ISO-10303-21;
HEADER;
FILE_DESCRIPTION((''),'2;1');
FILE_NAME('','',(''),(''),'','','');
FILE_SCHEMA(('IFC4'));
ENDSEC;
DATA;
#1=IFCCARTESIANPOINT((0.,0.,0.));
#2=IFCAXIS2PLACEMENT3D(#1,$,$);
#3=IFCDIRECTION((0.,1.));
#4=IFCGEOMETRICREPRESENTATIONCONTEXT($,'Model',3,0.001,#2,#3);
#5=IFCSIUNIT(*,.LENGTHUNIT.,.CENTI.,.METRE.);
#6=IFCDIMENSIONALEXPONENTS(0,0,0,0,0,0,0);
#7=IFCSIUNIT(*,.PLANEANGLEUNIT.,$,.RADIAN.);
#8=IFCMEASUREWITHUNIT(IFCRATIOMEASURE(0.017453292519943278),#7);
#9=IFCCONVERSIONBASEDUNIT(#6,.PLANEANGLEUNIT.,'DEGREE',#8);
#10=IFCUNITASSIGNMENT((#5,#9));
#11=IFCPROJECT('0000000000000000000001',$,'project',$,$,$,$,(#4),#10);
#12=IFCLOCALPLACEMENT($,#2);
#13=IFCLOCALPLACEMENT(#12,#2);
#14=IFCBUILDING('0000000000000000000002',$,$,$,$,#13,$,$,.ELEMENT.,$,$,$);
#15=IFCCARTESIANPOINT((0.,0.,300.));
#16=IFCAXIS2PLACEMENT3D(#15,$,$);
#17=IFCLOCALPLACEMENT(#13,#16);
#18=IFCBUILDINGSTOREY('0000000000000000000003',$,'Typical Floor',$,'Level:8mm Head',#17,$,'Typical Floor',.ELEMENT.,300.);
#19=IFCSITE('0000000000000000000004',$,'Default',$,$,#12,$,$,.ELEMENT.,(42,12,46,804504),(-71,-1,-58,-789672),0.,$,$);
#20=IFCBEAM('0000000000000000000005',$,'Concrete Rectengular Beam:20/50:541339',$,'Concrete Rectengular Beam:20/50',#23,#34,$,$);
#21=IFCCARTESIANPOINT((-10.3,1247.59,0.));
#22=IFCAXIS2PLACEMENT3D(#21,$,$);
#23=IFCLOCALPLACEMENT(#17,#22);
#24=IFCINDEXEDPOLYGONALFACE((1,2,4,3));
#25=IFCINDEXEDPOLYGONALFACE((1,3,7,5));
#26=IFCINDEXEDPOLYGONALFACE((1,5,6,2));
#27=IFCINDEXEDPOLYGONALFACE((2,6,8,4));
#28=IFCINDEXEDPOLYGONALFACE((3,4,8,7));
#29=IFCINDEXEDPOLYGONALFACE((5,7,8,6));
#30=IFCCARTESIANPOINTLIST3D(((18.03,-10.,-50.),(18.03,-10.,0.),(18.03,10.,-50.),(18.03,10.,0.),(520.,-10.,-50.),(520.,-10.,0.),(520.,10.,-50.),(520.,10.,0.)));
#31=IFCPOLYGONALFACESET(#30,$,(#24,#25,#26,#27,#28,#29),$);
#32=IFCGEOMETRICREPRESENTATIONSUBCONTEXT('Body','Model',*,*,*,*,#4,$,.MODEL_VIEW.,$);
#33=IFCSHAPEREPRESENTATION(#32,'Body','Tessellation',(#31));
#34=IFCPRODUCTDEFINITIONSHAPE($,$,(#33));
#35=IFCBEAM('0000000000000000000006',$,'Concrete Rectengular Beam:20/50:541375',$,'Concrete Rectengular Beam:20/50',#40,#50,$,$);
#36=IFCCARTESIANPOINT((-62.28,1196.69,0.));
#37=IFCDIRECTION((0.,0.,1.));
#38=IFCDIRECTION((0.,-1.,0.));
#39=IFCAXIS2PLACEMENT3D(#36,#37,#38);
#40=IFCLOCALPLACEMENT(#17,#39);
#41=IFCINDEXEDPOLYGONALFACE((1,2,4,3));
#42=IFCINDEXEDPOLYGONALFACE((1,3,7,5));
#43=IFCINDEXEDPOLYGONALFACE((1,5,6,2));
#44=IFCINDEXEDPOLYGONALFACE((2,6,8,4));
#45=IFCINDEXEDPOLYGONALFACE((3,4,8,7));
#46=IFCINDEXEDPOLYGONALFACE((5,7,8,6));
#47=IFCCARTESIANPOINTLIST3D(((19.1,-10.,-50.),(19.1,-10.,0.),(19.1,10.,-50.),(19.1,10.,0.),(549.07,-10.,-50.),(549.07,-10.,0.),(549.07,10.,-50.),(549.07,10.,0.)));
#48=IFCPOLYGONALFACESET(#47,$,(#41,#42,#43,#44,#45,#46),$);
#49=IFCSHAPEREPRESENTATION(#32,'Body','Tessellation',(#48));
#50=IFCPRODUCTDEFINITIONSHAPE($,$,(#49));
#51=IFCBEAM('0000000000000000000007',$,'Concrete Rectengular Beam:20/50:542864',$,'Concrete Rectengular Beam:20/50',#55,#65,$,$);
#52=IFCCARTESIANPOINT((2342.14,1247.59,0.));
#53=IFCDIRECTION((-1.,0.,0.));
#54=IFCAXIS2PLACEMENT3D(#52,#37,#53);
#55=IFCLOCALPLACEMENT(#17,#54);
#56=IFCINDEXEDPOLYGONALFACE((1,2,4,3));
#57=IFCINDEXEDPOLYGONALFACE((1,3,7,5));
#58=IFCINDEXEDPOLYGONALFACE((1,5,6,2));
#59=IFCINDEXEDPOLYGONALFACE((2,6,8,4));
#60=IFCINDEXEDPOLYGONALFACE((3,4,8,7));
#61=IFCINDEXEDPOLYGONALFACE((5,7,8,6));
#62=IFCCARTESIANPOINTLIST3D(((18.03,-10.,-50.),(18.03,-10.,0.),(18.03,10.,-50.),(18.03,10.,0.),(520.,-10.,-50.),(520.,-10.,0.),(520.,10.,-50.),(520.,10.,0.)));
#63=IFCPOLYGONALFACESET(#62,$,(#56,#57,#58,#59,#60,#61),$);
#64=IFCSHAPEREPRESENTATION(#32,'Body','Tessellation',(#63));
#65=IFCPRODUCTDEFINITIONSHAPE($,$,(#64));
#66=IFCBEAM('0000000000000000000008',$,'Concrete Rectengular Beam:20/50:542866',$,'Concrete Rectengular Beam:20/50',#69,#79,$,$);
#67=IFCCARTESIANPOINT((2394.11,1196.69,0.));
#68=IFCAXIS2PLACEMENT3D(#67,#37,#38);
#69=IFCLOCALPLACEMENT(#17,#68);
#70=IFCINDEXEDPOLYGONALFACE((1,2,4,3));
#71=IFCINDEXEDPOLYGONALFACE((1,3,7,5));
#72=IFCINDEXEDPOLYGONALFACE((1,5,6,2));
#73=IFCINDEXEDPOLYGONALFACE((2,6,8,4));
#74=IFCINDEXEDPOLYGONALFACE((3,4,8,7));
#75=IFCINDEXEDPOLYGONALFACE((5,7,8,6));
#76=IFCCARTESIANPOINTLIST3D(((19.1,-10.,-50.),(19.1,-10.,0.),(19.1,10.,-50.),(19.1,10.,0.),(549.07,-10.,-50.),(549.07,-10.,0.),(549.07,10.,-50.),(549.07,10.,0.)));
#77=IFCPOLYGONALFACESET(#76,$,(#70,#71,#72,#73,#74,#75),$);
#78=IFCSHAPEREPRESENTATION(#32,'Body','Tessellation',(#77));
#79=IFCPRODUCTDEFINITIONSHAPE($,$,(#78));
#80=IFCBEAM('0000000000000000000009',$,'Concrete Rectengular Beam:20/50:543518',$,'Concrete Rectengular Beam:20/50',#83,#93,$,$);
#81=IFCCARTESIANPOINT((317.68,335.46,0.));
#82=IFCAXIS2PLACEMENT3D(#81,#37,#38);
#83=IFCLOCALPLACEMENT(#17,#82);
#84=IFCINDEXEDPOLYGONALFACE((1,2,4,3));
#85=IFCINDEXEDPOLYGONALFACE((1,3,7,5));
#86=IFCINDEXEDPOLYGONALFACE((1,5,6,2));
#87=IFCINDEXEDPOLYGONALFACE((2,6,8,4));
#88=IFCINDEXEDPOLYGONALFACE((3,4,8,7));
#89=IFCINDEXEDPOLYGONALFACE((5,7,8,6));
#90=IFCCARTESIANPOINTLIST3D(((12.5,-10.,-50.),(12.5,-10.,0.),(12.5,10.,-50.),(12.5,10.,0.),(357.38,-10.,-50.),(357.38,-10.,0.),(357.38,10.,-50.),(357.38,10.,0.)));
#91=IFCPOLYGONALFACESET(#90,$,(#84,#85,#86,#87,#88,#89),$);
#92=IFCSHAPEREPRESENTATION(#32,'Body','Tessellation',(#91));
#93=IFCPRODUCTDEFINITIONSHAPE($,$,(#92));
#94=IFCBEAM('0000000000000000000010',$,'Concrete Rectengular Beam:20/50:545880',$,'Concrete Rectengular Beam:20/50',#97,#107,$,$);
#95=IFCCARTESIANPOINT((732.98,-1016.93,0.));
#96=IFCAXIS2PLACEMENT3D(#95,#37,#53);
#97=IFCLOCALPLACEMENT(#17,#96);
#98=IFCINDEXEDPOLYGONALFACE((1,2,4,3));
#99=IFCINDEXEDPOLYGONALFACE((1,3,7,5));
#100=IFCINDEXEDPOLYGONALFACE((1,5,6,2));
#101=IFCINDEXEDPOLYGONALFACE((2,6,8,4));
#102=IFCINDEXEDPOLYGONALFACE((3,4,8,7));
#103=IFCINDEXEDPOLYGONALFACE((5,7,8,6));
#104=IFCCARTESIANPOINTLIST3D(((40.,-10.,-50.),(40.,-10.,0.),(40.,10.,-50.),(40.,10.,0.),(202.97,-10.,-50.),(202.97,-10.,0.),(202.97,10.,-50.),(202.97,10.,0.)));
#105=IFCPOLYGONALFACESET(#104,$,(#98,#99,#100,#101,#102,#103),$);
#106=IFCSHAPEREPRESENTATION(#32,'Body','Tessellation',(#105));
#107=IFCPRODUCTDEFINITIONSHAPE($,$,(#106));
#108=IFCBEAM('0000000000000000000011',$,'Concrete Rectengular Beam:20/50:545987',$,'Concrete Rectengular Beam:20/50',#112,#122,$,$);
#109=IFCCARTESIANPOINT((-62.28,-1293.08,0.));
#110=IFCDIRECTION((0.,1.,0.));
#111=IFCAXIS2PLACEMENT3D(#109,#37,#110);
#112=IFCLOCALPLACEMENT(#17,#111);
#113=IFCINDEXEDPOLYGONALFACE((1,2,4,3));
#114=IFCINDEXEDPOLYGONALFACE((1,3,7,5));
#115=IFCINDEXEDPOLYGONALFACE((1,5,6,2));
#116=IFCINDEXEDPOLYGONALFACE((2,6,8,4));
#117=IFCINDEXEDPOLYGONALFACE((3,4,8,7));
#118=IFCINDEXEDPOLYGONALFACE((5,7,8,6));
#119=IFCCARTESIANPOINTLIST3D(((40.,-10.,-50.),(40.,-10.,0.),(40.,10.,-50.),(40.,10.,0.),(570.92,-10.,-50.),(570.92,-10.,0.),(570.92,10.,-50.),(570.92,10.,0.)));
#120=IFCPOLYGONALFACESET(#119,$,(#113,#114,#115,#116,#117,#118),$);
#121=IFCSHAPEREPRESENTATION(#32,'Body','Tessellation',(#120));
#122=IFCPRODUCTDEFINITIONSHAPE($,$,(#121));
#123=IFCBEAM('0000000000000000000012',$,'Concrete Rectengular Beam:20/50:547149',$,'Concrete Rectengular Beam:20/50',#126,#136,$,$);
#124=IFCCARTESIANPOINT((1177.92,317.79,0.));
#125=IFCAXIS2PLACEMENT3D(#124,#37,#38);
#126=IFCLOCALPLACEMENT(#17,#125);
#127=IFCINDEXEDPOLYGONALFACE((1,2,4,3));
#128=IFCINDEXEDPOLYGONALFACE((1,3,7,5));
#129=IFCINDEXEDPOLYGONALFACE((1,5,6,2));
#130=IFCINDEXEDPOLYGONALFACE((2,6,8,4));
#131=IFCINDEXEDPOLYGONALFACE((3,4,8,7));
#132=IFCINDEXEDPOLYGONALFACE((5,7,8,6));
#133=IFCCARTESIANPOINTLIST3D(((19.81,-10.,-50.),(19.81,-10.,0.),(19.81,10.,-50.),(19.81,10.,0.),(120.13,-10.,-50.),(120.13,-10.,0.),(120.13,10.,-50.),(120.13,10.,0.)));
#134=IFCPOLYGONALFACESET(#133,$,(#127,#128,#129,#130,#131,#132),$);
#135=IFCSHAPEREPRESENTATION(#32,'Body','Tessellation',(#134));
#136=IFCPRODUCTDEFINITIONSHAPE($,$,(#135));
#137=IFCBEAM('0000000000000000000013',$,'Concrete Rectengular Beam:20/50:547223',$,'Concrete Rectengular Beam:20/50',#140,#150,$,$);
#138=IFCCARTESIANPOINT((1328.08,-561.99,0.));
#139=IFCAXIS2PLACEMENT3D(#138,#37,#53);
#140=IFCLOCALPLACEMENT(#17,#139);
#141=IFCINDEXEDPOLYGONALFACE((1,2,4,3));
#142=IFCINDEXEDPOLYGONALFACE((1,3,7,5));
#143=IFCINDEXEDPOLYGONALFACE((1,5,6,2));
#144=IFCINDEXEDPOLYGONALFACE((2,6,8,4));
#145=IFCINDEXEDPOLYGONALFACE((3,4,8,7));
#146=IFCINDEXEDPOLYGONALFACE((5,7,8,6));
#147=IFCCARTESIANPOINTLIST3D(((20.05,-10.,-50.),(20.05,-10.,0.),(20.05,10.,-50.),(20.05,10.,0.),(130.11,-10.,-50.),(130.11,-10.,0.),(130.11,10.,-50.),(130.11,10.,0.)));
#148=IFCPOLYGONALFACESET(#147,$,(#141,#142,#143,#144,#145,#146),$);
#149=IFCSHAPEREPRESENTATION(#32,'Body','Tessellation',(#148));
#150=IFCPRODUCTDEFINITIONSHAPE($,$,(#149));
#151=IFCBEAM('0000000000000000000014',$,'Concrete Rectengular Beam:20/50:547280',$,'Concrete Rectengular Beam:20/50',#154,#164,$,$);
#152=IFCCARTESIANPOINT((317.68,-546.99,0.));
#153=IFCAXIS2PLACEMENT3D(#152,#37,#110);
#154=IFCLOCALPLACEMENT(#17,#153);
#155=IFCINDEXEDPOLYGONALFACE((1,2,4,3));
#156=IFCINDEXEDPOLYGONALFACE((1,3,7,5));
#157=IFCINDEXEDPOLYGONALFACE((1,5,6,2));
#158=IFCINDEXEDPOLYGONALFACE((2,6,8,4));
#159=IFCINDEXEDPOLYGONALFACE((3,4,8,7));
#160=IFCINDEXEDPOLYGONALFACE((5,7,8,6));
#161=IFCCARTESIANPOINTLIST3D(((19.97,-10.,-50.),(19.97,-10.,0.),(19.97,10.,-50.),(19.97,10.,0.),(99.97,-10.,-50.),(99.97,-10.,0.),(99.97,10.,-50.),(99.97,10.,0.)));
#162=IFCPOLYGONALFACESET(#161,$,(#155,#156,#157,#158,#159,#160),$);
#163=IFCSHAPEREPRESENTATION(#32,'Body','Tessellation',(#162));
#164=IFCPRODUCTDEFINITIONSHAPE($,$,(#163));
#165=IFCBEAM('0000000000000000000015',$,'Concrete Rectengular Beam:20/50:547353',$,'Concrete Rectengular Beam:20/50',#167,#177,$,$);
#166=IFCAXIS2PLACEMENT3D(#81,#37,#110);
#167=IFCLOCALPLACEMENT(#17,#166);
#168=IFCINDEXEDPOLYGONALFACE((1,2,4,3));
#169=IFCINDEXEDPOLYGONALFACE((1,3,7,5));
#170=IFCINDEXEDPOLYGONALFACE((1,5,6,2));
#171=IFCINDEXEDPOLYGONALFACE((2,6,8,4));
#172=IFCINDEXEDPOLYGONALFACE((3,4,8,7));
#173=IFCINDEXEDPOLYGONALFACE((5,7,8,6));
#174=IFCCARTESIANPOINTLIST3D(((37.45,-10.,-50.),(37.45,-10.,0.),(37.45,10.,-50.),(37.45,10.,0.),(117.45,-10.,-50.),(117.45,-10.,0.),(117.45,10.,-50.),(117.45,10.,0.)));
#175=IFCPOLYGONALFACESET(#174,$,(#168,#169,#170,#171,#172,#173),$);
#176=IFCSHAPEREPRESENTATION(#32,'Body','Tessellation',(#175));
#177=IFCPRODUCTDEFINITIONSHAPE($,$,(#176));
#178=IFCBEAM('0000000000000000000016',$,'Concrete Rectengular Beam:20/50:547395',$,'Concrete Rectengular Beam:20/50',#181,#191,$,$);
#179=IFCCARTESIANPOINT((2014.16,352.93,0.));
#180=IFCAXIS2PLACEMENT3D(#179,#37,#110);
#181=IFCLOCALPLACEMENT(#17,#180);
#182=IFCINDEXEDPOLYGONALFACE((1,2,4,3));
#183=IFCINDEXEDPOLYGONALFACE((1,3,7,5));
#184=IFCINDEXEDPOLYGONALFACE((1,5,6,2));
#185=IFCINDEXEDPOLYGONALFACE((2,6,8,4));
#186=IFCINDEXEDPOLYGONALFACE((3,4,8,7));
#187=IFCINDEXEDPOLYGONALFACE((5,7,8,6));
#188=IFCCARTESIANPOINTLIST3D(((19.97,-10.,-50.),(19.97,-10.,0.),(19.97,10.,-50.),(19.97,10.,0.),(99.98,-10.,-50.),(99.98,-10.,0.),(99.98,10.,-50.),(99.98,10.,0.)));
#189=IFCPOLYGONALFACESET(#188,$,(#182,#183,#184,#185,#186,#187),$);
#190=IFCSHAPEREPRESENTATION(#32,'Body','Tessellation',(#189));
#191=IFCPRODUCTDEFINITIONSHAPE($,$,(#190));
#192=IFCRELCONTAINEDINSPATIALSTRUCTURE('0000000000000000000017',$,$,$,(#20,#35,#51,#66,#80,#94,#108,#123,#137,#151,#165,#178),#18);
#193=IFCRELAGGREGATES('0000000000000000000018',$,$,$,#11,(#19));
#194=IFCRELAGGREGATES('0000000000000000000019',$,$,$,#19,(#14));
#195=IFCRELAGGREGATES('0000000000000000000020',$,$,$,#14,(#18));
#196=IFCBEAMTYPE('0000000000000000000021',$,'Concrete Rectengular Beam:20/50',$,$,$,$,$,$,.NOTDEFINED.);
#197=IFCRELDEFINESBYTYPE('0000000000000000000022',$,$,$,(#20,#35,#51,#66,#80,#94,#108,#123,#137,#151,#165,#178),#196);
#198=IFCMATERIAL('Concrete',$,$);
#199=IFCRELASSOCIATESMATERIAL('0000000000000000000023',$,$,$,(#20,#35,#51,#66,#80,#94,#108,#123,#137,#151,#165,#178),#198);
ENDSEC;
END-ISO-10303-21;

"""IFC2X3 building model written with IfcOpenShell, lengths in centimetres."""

from ifc_helpers import new_model, entity, si_unit, converted_unit, direction, frame, frame_2d, origin, origin_2d_with_axis, place, context, subcontext, project, spatial, rectangle, extrude, material, type_object, element, save


model = new_model("IFC2X3")

# Units and contexts
model_context = context("Model", 3, precision=0.001, world=origin(), true_north=direction((0.0, 1.0)))
body_context = subcontext(model_context, "Body", "Model", "MODEL_VIEW")
ifc_project = project(units=[si_unit("LENGTHUNIT", "METRE", prefix="CENTI"), converted_unit("PLANEANGLEUNIT", "DEGREE", entity("IfcRatioMeasure", 0.017453292519943278), si_unit("PLANEANGLEUNIT", "RADIAN"), dimensions=[0, 0, 0, 0, 0, 0, 0])], contexts=[model_context])

# Site, building, storey
site_placement = place(None, origin())
site = spatial("IfcSite", under=ifc_project, at=site_placement, Name="Default", CompositionType="ELEMENT", RefLatitude=(42, 12, 46, 804504), RefLongitude=(-71, -1, -58, -789672), RefElevation=0.0)
building_placement = place(site_placement, origin())
building = spatial("IfcBuilding", under=site, at=building_placement, CompositionType="ELEMENT")
storey_placement = place(building_placement, frame((0.0, 0.0, 300.0)))
storey = spatial("IfcBuildingStorey", under=building, at=storey_placement, Name="Typical Floor", ObjectType="Level:8mm Head", LongName="Typical Floor", CompositionType="ELEMENT", Elevation=300.0)

# Beams
ifc_material = material(Name="Concrete")
beam_type = type_object("IfcBeamType", Name="Concrete Rectengular Beam:20/50", PredefinedType="NOTDEFINED")
beam_1_placement = place(storey_placement, frame((-10.3, 1247.59, 0.0)))
element("IfcBeam", 1, at=beam_1_placement, inside=storey, type_object=beam_type, material=ifc_material, Name="Concrete Rectengular Beam:20/50:541339", ObjectType="Concrete Rectengular Beam:20/50", context=body_context, shape_type="SweptSolid", body=[
    extrude(rectangle(XDim=50.0, YDim=20.0, at=frame_2d((0.0, 0.0), x_axis=(1.0, 0.0))), frame((18.03, 0.0, -25.0), z_axis=(1.0, 0.0, 0.0), x_axis=(0.0, 0.0, -1.0)), (0.0, 0.0, 1.0), 501.97),
])
beam_2_placement = place(storey_placement, frame((-62.28, 1196.69, 0.0), z_axis=(0.0, 0.0, 1.0), x_axis=(0.0, -1.0, 0.0)))
element("IfcBeam", 2, at=beam_2_placement, inside=storey, type_object=beam_type, material=ifc_material, Name="Concrete Rectengular Beam:20/50:541375", ObjectType="Concrete Rectengular Beam:20/50", context=body_context, shape_type="SweptSolid", body=[
    extrude(rectangle(XDim=50.0, YDim=20.0, at=origin_2d_with_axis()), frame((19.1, 0.0, -25.0), z_axis=(1.0, 0.0, 0.0), x_axis=(0.0, 0.0, -1.0)), (0.0, 0.0, 1.0), 529.97),
])
beam_3_placement = place(storey_placement, frame((2342.14, 1247.59, 0.0), z_axis=(0.0, 0.0, 1.0), x_axis=(-1.0, 0.0, 0.0)))
element("IfcBeam", 3, at=beam_3_placement, inside=storey, type_object=beam_type, material=ifc_material, Name="Concrete Rectengular Beam:20/50:542864", ObjectType="Concrete Rectengular Beam:20/50", context=body_context, shape_type="SweptSolid", body=[
    extrude(rectangle(XDim=50.0, YDim=20.0, at=frame_2d((0.0, 0.0), x_axis=(1.0, 0.0))), frame((18.03, 0.0, -25.0), z_axis=(1.0, 0.0, 0.0), x_axis=(0.0, 0.0, -1.0)), (0.0, 0.0, 1.0), 501.97),
])
beam_4_placement = place(storey_placement, frame((2394.11, 1196.69, 0.0), z_axis=(0.0, 0.0, 1.0), x_axis=(0.0, -1.0, 0.0)))
element("IfcBeam", 4, at=beam_4_placement, inside=storey, type_object=beam_type, material=ifc_material, Name="Concrete Rectengular Beam:20/50:542866", ObjectType="Concrete Rectengular Beam:20/50", context=body_context, shape_type="SweptSolid", body=[
    extrude(rectangle(XDim=50.0, YDim=20.0, at=frame_2d((0.0, 0.0), x_axis=(1.0, 0.0))), frame((19.1, 0.0, -25.0), z_axis=(1.0, 0.0, 0.0), x_axis=(0.0, 0.0, -1.0)), (0.0, 0.0, 1.0), 529.97),
])
beam_5_placement = place(storey_placement, frame((317.68, 335.46, 0.0), z_axis=(0.0, 0.0, 1.0), x_axis=(0.0, -1.0, 0.0)))
element("IfcBeam", 5, at=beam_5_placement, inside=storey, type_object=beam_type, material=ifc_material, Name="Concrete Rectengular Beam:20/50:543518", ObjectType="Concrete Rectengular Beam:20/50", context=body_context, shape_type="SweptSolid", body=[
    extrude(rectangle(XDim=50.0, YDim=20.0, at=frame_2d((0.0, 0.0), x_axis=(1.0, 0.0))), frame((12.5, 0.0, -25.0), z_axis=(1.0, 0.0, 0.0), x_axis=(0.0, 0.0, -1.0)), (0.0, 0.0, 1.0), 344.88),
])
beam_6_placement = place(storey_placement, frame((732.98, -1016.93, 0.0), z_axis=(0.0, 0.0, 1.0), x_axis=(-1.0, 0.0, 0.0)))
element("IfcBeam", 6, at=beam_6_placement, inside=storey, type_object=beam_type, material=ifc_material, Name="Concrete Rectengular Beam:20/50:545880", ObjectType="Concrete Rectengular Beam:20/50", context=body_context, shape_type="SweptSolid", body=[
    extrude(rectangle(XDim=50.0, YDim=20.0, at=frame_2d((0.0, 0.0), x_axis=(1.0, 0.0))), frame((40.0, 0.0, -25.0), z_axis=(1.0, 0.0, 0.0), x_axis=(0.0, 0.0, -1.0)), (0.0, 0.0, 1.0), 162.97),
])
beam_7_placement = place(storey_placement, frame((-62.28, -1293.08, 0.0), z_axis=(0.0, 0.0, 1.0), x_axis=(0.0, 1.0, 0.0)))
element("IfcBeam", 7, at=beam_7_placement, inside=storey, type_object=beam_type, material=ifc_material, Name="Concrete Rectengular Beam:20/50:545987", ObjectType="Concrete Rectengular Beam:20/50", context=body_context, shape_type="SweptSolid", body=[
    extrude(rectangle(XDim=50.0, YDim=20.0, at=frame_2d((0.0, 0.0), x_axis=(1.0, 0.0))), frame((40.0, 0.0, -25.0), z_axis=(1.0, 0.0, 0.0), x_axis=(0.0, 0.0, -1.0)), (0.0, 0.0, 1.0), 530.92),
])
beam_8_placement = place(storey_placement, frame((1177.92, 317.79, 0.0), z_axis=(0.0, 0.0, 1.0), x_axis=(0.0, -1.0, 0.0)))
element("IfcBeam", 8, at=beam_8_placement, inside=storey, type_object=beam_type, material=ifc_material, Name="Concrete Rectengular Beam:20/50:547149", ObjectType="Concrete Rectengular Beam:20/50", context=body_context, shape_type="SweptSolid", body=[
    extrude(rectangle(XDim=50.0, YDim=20.0, at=frame_2d((0.0, 0.0), x_axis=(1.0, 0.0))), frame((19.81, 0.0, -25.0), z_axis=(1.0, 0.0, 0.0), x_axis=(0.0, 0.0, -1.0)), (0.0, 0.0, 1.0), 100.32),
])
beam_9_placement = place(storey_placement, frame((1328.08, -561.99, 0.0), z_axis=(0.0, 0.0, 1.0), x_axis=(-1.0, 0.0, 0.0)))
element("IfcBeam", 9, at=beam_9_placement, inside=storey, type_object=beam_type, material=ifc_material, Name="Concrete Rectengular Beam:20/50:547223", ObjectType="Concrete Rectengular Beam:20/50", context=body_context, shape_type="SweptSolid", body=[
    extrude(rectangle(XDim=50.0, YDim=20.0, at=frame_2d((0.0, 0.0), x_axis=(1.0, 0.0))), frame((20.05, 0.0, -25.0), z_axis=(1.0, 0.0, 0.0), x_axis=(0.0, 0.0, -1.0)), (0.0, 0.0, 1.0), 110.06),
])
beam_10_placement = place(storey_placement, frame((317.68, -546.99, 0.0), z_axis=(0.0, 0.0, 1.0), x_axis=(0.0, 1.0, 0.0)))
element("IfcBeam", 10, at=beam_10_placement, inside=storey, type_object=beam_type, material=ifc_material, Name="Concrete Rectengular Beam:20/50:547280", ObjectType="Concrete Rectengular Beam:20/50", context=body_context, shape_type="SweptSolid", body=[
    extrude(rectangle(XDim=50.0, YDim=20.0, at=frame_2d((0.0, 0.0), x_axis=(1.0, 0.0))), frame((19.97, 0.0, -25.0), z_axis=(1.0, 0.0, 0.0), x_axis=(0.0, 0.0, -1.0)), (0.0, 0.0, 1.0), 80.0),
])
beam_11_placement = place(storey_placement, frame((317.68, 335.46, 0.0), z_axis=(0.0, 0.0, 1.0), x_axis=(0.0, 1.0, 0.0)))
element("IfcBeam", 11, at=beam_11_placement, inside=storey, type_object=beam_type, material=ifc_material, Name="Concrete Rectengular Beam:20/50:547353", ObjectType="Concrete Rectengular Beam:20/50", context=body_context, shape_type="SweptSolid", body=[
    extrude(rectangle(XDim=50.0, YDim=20.0, at=frame_2d((0.0, 0.0), x_axis=(1.0, 0.0))), frame((37.45, 0.0, -25.0), z_axis=(1.0, 0.0, 0.0), x_axis=(0.0, 0.0, -1.0)), (0.0, 0.0, 1.0), 80.0),
])
beam_12_placement = place(storey_placement, frame((2014.16, 352.93, 0.0), z_axis=(0.0, 0.0, 1.0), x_axis=(0.0, 1.0, 0.0)))
element("IfcBeam", 12, at=beam_12_placement, inside=storey, type_object=beam_type, material=ifc_material, Name="Concrete Rectengular Beam:20/50:547395", ObjectType="Concrete Rectengular Beam:20/50", context=body_context, shape_type="SweptSolid", body=[
    extrude(rectangle(XDim=50.0, YDim=20.0, at=origin_2d_with_axis()), frame((19.97, 0.0, -25.0), z_axis=(1.0, 0.0, 0.0), x_axis=(0.0, 0.0, -1.0)), (0.0, 0.0, 1.0), 80.0),
])

save(model, "model.ifc")
